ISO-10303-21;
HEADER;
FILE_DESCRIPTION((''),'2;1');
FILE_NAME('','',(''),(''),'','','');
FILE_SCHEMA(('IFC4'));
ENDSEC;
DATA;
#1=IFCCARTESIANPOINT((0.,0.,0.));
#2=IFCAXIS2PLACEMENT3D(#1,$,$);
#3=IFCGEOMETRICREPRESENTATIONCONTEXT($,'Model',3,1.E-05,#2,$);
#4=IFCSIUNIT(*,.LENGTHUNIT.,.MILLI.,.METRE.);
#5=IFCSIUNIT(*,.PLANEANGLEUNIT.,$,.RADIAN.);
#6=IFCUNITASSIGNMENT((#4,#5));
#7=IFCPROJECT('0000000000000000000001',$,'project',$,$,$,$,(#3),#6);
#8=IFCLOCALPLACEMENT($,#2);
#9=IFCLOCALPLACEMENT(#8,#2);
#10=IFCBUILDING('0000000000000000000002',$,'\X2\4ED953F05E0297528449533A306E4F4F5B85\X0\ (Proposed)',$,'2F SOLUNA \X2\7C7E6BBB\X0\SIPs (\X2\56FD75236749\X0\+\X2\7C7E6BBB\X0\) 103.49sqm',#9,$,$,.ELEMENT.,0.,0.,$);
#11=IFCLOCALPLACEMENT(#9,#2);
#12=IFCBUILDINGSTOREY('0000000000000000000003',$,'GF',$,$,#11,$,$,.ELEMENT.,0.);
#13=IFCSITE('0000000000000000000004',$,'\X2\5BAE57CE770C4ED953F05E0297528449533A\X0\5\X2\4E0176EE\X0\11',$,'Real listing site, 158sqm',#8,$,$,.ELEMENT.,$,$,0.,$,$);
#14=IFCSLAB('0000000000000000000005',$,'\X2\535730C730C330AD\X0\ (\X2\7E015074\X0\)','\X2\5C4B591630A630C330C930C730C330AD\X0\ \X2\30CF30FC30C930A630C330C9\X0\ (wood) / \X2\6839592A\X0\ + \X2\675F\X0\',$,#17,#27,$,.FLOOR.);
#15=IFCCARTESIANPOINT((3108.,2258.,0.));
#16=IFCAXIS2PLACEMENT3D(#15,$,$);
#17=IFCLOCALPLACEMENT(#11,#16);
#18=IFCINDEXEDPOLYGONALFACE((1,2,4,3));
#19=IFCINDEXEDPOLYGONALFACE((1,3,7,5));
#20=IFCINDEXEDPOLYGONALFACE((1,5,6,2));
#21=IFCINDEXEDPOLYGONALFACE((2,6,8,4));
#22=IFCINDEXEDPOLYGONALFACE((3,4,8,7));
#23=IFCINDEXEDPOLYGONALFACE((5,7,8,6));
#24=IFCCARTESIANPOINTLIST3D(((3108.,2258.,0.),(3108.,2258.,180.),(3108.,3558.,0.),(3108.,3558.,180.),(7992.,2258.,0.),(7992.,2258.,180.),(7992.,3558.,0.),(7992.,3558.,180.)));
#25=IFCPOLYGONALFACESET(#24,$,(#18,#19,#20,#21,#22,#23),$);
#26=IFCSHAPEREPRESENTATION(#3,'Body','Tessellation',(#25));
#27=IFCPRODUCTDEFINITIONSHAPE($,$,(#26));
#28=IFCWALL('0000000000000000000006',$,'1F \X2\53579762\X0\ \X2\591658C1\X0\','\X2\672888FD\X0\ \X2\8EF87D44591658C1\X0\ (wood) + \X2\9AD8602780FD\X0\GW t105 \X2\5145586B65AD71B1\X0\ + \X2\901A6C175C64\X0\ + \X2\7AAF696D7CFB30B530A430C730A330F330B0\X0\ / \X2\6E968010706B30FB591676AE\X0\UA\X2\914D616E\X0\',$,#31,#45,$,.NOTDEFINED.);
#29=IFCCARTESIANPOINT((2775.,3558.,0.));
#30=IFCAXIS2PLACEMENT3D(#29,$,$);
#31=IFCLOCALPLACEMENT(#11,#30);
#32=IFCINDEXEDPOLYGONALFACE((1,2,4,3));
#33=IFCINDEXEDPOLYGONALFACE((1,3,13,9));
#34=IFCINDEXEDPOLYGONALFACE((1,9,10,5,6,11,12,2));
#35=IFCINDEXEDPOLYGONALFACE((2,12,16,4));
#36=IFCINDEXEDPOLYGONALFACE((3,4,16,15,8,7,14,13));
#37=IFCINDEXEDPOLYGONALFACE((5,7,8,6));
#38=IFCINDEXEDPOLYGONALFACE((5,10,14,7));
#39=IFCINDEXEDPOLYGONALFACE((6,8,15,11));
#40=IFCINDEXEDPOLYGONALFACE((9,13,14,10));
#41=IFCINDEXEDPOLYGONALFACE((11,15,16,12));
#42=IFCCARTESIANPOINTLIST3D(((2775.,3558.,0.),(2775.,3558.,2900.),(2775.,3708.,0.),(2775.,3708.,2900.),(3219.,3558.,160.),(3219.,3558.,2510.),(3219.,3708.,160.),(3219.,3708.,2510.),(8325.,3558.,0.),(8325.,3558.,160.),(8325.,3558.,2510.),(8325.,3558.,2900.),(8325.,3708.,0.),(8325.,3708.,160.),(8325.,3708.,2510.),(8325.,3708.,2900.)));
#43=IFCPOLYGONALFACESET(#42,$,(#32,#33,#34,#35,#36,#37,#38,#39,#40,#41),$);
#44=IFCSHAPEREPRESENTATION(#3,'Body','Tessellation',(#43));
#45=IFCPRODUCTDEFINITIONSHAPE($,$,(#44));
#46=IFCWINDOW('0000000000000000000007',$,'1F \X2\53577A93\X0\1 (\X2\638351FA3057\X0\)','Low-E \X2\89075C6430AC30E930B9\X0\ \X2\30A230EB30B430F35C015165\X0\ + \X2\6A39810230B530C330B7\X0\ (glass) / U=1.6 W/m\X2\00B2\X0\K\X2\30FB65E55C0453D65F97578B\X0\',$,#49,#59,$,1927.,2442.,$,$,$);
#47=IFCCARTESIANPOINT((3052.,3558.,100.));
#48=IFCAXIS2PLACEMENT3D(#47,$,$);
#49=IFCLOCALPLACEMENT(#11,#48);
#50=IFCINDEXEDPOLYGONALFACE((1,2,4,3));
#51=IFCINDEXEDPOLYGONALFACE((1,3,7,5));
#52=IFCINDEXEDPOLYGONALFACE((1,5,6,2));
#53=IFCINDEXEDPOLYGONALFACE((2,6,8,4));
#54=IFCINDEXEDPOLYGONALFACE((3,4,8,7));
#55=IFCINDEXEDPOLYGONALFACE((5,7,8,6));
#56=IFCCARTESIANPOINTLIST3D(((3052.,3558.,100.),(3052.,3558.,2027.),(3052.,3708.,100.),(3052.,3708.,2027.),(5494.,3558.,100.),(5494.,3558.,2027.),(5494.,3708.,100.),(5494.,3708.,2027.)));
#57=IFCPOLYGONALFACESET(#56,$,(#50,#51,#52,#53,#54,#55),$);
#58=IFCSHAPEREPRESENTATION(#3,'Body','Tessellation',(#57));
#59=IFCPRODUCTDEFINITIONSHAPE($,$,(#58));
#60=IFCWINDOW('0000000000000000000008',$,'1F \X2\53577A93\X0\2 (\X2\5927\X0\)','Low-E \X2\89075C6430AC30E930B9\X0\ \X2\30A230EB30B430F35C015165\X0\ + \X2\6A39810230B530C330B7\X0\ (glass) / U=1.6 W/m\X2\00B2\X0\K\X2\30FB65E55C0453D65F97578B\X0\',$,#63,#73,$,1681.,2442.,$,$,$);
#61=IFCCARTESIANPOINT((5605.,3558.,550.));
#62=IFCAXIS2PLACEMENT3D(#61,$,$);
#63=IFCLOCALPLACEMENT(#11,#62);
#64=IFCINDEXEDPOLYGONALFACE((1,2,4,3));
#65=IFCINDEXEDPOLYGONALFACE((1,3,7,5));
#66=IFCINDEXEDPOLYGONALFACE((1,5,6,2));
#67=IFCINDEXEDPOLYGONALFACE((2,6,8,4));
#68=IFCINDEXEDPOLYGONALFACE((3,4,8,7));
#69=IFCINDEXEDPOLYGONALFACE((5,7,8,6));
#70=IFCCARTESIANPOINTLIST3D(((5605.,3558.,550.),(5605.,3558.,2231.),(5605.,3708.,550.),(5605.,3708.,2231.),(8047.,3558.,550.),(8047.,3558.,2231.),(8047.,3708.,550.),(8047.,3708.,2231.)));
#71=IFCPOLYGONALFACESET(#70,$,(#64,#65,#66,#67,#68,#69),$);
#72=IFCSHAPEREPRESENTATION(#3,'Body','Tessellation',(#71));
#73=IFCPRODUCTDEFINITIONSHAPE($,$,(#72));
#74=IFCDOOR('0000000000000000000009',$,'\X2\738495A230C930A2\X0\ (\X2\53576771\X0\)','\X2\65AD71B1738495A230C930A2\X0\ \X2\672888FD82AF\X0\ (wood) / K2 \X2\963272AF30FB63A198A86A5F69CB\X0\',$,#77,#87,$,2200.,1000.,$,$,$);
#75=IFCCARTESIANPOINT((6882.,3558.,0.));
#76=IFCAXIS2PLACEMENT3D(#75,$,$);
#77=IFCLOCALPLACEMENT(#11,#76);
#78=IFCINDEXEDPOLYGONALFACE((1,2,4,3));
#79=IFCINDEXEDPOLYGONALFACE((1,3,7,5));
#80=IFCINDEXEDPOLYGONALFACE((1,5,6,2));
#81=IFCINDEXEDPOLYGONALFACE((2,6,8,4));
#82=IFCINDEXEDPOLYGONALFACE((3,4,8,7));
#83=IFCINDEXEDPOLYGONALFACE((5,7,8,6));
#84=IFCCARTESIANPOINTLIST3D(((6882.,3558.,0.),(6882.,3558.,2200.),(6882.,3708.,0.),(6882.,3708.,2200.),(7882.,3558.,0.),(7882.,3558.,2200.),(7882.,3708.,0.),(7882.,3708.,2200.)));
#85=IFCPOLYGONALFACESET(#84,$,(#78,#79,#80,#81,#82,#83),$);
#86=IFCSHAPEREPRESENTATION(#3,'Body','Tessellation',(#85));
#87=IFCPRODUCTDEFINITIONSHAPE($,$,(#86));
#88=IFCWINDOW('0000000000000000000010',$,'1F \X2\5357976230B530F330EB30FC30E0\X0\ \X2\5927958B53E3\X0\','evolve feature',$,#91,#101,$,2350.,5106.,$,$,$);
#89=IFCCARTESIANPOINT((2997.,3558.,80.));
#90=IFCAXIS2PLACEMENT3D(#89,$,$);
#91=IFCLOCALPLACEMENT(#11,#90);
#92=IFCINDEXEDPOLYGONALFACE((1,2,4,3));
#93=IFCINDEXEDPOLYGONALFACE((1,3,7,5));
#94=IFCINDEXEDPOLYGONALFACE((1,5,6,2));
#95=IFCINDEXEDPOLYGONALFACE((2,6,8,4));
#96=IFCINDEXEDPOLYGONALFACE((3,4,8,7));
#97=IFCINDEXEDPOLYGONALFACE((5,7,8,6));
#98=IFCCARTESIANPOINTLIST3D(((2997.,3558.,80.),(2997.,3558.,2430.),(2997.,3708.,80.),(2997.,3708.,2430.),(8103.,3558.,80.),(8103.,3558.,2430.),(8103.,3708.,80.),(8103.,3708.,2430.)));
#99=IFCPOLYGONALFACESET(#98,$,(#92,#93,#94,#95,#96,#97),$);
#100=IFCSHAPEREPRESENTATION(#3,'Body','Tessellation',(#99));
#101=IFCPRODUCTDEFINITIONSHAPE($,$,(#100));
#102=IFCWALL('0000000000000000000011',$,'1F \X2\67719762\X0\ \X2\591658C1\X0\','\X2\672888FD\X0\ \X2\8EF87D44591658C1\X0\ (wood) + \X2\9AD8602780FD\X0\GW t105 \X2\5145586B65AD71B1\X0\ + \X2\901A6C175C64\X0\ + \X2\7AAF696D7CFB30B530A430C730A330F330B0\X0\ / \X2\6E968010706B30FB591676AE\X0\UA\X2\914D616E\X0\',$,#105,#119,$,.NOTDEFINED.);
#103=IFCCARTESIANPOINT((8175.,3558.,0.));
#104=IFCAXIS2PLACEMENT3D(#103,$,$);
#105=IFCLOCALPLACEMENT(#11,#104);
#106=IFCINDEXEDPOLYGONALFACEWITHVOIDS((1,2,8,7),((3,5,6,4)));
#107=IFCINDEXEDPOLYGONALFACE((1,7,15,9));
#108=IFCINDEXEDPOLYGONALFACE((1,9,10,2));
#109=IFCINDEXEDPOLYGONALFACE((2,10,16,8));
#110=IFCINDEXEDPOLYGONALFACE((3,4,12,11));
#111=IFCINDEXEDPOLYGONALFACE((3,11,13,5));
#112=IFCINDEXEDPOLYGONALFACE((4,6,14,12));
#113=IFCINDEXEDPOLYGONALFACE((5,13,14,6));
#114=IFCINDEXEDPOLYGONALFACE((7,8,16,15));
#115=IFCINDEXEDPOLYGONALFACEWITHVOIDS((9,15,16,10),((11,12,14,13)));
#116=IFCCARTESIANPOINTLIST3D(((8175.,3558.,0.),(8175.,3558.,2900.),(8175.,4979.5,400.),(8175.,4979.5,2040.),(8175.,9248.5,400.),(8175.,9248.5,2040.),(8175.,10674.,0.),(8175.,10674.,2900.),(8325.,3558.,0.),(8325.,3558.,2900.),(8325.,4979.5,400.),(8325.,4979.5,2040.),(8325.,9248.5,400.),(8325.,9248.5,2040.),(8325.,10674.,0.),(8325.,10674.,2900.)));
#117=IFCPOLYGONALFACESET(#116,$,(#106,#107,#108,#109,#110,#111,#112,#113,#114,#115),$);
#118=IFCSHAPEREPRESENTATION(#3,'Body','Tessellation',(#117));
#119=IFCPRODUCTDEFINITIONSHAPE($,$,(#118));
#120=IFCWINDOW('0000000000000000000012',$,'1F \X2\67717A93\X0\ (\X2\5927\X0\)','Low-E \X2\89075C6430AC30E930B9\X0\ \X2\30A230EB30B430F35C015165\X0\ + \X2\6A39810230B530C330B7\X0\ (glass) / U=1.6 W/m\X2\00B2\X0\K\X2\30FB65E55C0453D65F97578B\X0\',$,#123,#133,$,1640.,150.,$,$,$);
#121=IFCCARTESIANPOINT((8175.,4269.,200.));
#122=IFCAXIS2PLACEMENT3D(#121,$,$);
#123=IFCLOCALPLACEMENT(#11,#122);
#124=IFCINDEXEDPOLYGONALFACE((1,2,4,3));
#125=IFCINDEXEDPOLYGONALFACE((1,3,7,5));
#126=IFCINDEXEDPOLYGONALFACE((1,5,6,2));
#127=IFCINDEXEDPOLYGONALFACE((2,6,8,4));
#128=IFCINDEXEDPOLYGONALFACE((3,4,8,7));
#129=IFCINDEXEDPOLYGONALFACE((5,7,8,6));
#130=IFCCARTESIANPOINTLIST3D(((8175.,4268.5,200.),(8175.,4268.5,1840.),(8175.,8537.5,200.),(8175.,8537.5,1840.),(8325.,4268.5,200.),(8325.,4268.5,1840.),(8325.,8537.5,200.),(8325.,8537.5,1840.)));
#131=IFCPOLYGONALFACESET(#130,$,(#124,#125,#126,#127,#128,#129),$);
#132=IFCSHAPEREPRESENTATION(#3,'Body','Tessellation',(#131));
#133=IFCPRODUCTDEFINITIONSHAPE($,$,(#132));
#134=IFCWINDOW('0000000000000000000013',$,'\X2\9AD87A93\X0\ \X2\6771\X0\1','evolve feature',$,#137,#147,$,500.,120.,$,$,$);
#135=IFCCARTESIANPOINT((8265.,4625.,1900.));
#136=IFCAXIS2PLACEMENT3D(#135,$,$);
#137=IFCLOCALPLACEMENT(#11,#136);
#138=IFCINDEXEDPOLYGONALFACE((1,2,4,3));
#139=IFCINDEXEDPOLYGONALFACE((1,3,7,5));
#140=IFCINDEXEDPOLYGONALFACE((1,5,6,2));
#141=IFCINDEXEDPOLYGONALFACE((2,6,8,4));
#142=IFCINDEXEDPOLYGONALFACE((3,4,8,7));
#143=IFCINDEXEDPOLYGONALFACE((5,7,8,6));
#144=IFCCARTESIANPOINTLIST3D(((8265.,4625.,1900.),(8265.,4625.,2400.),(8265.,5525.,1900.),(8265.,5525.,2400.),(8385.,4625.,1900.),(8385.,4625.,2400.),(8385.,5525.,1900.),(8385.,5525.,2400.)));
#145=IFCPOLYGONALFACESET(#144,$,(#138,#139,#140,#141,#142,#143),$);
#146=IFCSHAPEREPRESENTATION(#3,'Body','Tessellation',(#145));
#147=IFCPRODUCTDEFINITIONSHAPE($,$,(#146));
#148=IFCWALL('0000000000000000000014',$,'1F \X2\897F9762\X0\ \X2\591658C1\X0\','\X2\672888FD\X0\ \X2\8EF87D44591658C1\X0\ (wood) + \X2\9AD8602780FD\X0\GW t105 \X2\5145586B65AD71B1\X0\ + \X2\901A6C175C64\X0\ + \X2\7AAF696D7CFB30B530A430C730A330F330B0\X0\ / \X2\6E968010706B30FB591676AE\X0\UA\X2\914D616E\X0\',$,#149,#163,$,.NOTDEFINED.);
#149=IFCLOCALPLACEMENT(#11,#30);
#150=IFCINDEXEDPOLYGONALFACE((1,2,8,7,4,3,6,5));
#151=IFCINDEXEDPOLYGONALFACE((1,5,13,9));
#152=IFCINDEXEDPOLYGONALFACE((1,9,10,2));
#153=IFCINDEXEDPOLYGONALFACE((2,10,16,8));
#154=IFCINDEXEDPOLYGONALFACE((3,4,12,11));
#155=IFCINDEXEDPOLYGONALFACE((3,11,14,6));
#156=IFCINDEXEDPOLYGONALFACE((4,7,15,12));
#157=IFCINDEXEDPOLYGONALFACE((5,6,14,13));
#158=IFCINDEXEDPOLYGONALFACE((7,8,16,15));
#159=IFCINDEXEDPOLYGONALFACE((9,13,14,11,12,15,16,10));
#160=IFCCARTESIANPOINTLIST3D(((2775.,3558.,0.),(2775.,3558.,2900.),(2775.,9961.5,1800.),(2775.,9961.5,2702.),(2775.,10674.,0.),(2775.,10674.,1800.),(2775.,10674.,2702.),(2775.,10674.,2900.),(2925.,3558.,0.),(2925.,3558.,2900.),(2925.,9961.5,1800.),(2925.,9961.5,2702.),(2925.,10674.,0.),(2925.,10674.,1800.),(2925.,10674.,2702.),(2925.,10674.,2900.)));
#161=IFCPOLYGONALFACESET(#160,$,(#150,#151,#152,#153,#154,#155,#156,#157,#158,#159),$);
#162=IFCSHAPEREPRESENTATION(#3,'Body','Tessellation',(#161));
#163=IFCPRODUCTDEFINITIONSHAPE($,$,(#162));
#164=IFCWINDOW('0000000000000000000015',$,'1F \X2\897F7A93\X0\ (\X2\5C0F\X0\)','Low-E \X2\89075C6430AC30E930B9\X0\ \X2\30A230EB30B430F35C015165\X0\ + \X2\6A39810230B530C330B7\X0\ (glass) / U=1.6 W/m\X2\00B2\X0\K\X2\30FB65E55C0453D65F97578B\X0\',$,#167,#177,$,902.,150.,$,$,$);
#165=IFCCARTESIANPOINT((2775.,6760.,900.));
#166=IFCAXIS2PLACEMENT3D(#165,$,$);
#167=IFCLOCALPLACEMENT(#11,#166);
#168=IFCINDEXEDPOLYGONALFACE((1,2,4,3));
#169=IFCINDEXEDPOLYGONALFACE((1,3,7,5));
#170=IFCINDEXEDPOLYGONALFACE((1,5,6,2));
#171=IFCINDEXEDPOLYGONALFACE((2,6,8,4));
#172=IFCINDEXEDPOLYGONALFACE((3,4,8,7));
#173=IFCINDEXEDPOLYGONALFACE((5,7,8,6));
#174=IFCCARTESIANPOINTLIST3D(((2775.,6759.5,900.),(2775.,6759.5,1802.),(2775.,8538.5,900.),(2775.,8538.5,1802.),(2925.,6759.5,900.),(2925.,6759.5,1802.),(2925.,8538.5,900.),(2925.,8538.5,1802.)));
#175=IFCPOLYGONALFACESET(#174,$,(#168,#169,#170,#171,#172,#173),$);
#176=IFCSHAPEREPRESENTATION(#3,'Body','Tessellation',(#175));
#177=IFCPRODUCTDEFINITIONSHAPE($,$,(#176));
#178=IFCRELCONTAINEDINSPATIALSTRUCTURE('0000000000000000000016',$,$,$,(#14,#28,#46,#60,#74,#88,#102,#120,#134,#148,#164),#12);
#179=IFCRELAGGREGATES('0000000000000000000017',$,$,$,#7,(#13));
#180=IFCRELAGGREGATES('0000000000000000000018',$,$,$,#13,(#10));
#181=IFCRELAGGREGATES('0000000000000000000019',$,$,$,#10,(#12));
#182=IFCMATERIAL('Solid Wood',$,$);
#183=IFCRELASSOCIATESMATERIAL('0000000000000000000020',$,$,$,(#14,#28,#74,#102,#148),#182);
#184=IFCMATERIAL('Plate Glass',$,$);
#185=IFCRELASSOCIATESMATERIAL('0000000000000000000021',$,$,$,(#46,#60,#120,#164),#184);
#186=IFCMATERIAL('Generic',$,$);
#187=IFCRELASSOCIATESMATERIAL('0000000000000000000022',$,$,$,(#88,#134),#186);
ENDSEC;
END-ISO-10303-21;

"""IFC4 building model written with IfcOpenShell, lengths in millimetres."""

from ifc_helpers import new_model, si_unit, frame, frame_2d, origin, place, context, project, spatial, rectangle, extrude, material, element, fill, save


model = new_model("IFC4")

# Units and contexts
model_context = context("Model", 3, precision=1e-05, world=origin())
ifc_project = project(units=[si_unit("LENGTHUNIT", "METRE", prefix="MILLI"), si_unit("PLANEANGLEUNIT", "RADIAN")], contexts=[model_context])

# Site, building, storey
site_placement = place(None, origin())
site = spatial("IfcSite", under=ifc_project, at=site_placement, Name="宮城県仙台市青葉区5丁目11", ObjectType="Real listing site, 158sqm", CompositionType="ELEMENT", RefElevation=0.0)
building_placement = place(site_placement, origin())
building = spatial("IfcBuilding", under=site, at=building_placement, Name="仙台市青葉区の住宅 (Proposed)", ObjectType="2F SOLUNA 籾殻SIPs (国産杉+籾殻) 103.49sqm", CompositionType="ELEMENT", ElevationOfRefHeight=0.0, ElevationOfTerrain=0.0)
storey_placement = place(building_placement, origin())
storey = spatial("IfcBuildingStorey", under=building, at=storey_placement, Name="GF", CompositionType="ELEMENT", Elevation=0.0)

# Slab
ifc_material_1 = material(Name="Solid Wood")
slab_1_placement = place(storey_placement, frame((3108.0, 2258.0, 0.0)))
element("IfcSlab", 1, at=slab_1_placement, inside=storey, material=ifc_material_1, Name="南デッキ (縁側)", Description="屋外ウッドデッキ ハードウッド (wood) / 根太 + 束", PredefinedType="FLOOR", context=model_context, shape_type="SweptSolid", body=[
    extrude(rectangle(XDim=4884.0, YDim=1300.0, at=frame_2d((2442.0, 650.0))), frame((3108.0, 2258.0, 0.0)), (0.0, 0.0, 1.0), 180.0),
])
ifc_material_2 = material(Name="Generic")

# Wall, openings, windows, door
wall_1_placement = place(storey_placement, frame((2775.0, 3558.0, 0.0)))
wall_1 = element("IfcWall", 2, at=wall_1_placement, inside=storey, material=ifc_material_1, Name="1F 南面 外壁", Description="木製 軸組外壁 (wood) + 高性能GW t105 充填断熱 + 通気層 + 窯業系サイディング / 準耐火・外皮UA配慮", PredefinedType="NOTDEFINED", context=model_context, shape_type="SweptSolid", body=[
    extrude(rectangle(XDim=5550.0, YDim=150.0, at=frame_2d((2775.0, 75.0))), frame((2775.0, 3558.0, 0.0)), (0.0, 0.0, 1.0), 2900.0),
])
opening_1_placement = place(storey_placement, frame((3052.0, 3558.0, 100.0)))
opening_1 = element("IfcOpeningElement", 3, at=opening_1_placement, cuts=wall_1, PredefinedType="NOTDEFINED", context=model_context, shape_type="SweptSolid", body=[
    extrude(rectangle(XDim=2442.0, YDim=150.0, at=frame_2d((1221.0, 75.0))), frame((3052.0, 3558.0, 100.0)), (0.0, 0.0, 1.0), 1927.0),
])
opening_2_placement = place(storey_placement, frame((5605.0, 3558.0, 550.0)))
opening_2 = element("IfcOpeningElement", 4, at=opening_2_placement, cuts=wall_1, PredefinedType="NOTDEFINED", context=model_context, shape_type="SweptSolid", body=[
    extrude(rectangle(XDim=2442.0, YDim=150.0, at=frame_2d((1221.0, 75.0))), frame((5605.0, 3558.0, 550.0)), (0.0, 0.0, 1.0), 1681.0),
])
opening_3_placement = place(storey_placement, frame((6882.0, 3558.0, 0.0)))
opening_3 = element("IfcOpeningElement", 5, at=opening_3_placement, cuts=wall_1, PredefinedType="NOTDEFINED", context=model_context, shape_type="SweptSolid", body=[
    extrude(rectangle(XDim=1000.0, YDim=150.0, at=frame_2d((500.0, 75.0))), frame((6882.0, 3558.0, 0.0)), (0.0, 0.0, 1.0), 2200.0),
])
opening_4_placement = place(storey_placement, frame((2997.0, 3558.0, 80.0)))
opening_4 = element("IfcOpeningElement", 6, at=opening_4_placement, cuts=wall_1, PredefinedType="NOTDEFINED", context=model_context, shape_type="SweptSolid", body=[
    extrude(rectangle(XDim=5106.0, YDim=150.0, at=frame_2d((2553.0, 75.0))), frame((2997.0, 3558.0, 80.0)), (0.0, 0.0, 1.0), 2350.0),
])
ifc_material_3 = material(Name="Plate Glass")
window_1_placement = place(storey_placement, frame((3052.0, 3558.0, 100.0)))
window_1 = element("IfcWindow", 7, at=window_1_placement, inside=storey, material=ifc_material_3, Name="1F 南窓1 (掃出し)", Description="Low-E 複層ガラス アルゴン封入 + 樹脂サッシ (glass) / U=1.6 W/m²K・日射取得型", OverallHeight=1927.0, OverallWidth=2442.0, context=model_context, shape_type="SweptSolid", body=[
    extrude(rectangle(XDim=2442.0, YDim=150.0, at=frame_2d((1221.0, 75.0))), frame((3052.0, 3558.0, 100.0)), (0.0, 0.0, 1.0), 1927.0),
])
fill(opening_1, window_1)
window_2_placement = place(storey_placement, frame((5605.0, 3558.0, 550.0)))
window_2 = element("IfcWindow", 8, at=window_2_placement, inside=storey, material=ifc_material_3, Name="1F 南窓2 (大)", Description="Low-E 複層ガラス アルゴン封入 + 樹脂サッシ (glass) / U=1.6 W/m²K・日射取得型", OverallHeight=1681.0, OverallWidth=2442.0, context=model_context, shape_type="SweptSolid", body=[
    extrude(rectangle(XDim=2442.0, YDim=150.0, at=frame_2d((1221.0, 75.0))), frame((5605.0, 3558.0, 550.0)), (0.0, 0.0, 1.0), 1681.0),
])
fill(opening_2, window_2)
door_placement = place(storey_placement, frame((6882.0, 3558.0, 0.0)))
door = element("IfcDoor", 9, at=door_placement, inside=storey, material=ifc_material_1, Name="玄関ドア (南東)", Description="断熱玄関ドア 木製芯 (wood) / K2 防犯・採風機構", OverallHeight=2200.0, OverallWidth=1000.0, context=model_context, shape_type="SweptSolid", body=[
    extrude(rectangle(XDim=1000.0, YDim=150.0, at=frame_2d((500.0, 75.0))), frame((6882.0, 3558.0, 0.0)), (0.0, 0.0, 1.0), 2200.0),
])
fill(opening_3, door)
window_3_placement = place(storey_placement, frame((2997.0, 3558.0, 80.0)))
window_3 = element("IfcWindow", 10, at=window_3_placement, inside=storey, material=ifc_material_2, Name="1F 南面サンルーム 大開口", Description="evolve feature", OverallHeight=2350.0, OverallWidth=5106.0, context=model_context, shape_type="SweptSolid", body=[
    extrude(rectangle(XDim=5106.0, YDim=150.0, at=frame_2d((2553.0, 75.0))), frame((2997.0, 3558.0, 80.0)), (0.0, 0.0, 1.0), 2350.0),
])
fill(opening_4, window_3)

# Wall, openings, windows
wall_2_placement = place(storey_placement, frame((8175.0, 3558.0, 0.0)))
wall_2 = element("IfcWall", 11, at=wall_2_placement, inside=storey, material=ifc_material_1, Name="1F 東面 外壁", Description="木製 軸組外壁 (wood) + 高性能GW t105 充填断熱 + 通気層 + 窯業系サイディング / 準耐火・外皮UA配慮", PredefinedType="NOTDEFINED", context=model_context, shape_type="SweptSolid", body=[
    extrude(rectangle(XDim=150.0, YDim=7116.0, at=frame_2d((75.0, 3558.0))), frame((8175.0, 3558.0, 0.0)), (0.0, 0.0, 1.0), 2900.0),
])
opening_5_placement = place(storey_placement, frame((8175.0, 4269.0, 200.0)))
opening_5 = element("IfcOpeningElement", 12, at=opening_5_placement, cuts=wall_2, PredefinedType="NOTDEFINED", context=model_context, shape_type="SweptSolid", body=[
    extrude(rectangle(XDim=150.0, YDim=4269.0, at=frame_2d((75.0, 2134.0))), frame((8175.0, 4269.0, 200.0)), (0.0, 0.0, 1.0), 1640.0),
])
opening_6_placement = place(storey_placement, frame((8265.0, 4625.0, 1900.0)))
opening_6 = element("IfcOpeningElement", 13, at=opening_6_placement, cuts=wall_2, PredefinedType="NOTDEFINED", context=model_context, shape_type="SweptSolid", body=[
    extrude(rectangle(XDim=120.0, YDim=900.0, at=frame_2d((60.0, 450.0))), frame((8265.0, 4625.0, 1900.0)), (0.0, 0.0, 1.0), 500.0),
])
window_4_placement = place(storey_placement, frame((8175.0, 4269.0, 200.0)))
window_4 = element("IfcWindow", 14, at=window_4_placement, inside=storey, material=ifc_material_3, Name="1F 東窓 (大)", Description="Low-E 複層ガラス アルゴン封入 + 樹脂サッシ (glass) / U=1.6 W/m²K・日射取得型", OverallHeight=1640.0, OverallWidth=150.0, context=model_context, shape_type="SweptSolid", body=[
    extrude(rectangle(XDim=150.0, YDim=4269.0, at=frame_2d((75.0, 2134.0))), frame((8175.0, 4269.0, 200.0)), (0.0, 0.0, 1.0), 1640.0),
])
fill(opening_5, window_4)
window_5_placement = place(storey_placement, frame((8265.0, 4625.0, 1900.0)))
window_5 = element("IfcWindow", 15, at=window_5_placement, inside=storey, material=ifc_material_2, Name="高窓 東1", Description="evolve feature", OverallHeight=500.0, OverallWidth=120.0, context=model_context, shape_type="SweptSolid", body=[
    extrude(rectangle(XDim=120.0, YDim=900.0, at=frame_2d((60.0, 450.0))), frame((8265.0, 4625.0, 1900.0)), (0.0, 0.0, 1.0), 500.0),
])
fill(opening_6, window_5)

# Wall, opening, window
wall_3_placement = place(storey_placement, frame((2775.0, 3558.0, 0.0)))
wall_3 = element("IfcWall", 16, at=wall_3_placement, inside=storey, material=ifc_material_1, Name="1F 西面 外壁", Description="木製 軸組外壁 (wood) + 高性能GW t105 充填断熱 + 通気層 + 窯業系サイディング / 準耐火・外皮UA配慮", PredefinedType="NOTDEFINED", context=model_context, shape_type="SweptSolid", body=[
    extrude(rectangle(XDim=150.0, YDim=7116.0, at=frame_2d((75.0, 3558.0))), frame((2775.0, 3558.0, 0.0)), (0.0, 0.0, 1.0), 2900.0),
])
opening_7_placement = place(storey_placement, frame((2775.0, 6760.0, 900.0)))
opening_7 = element("IfcOpeningElement", 17, at=opening_7_placement, cuts=wall_3, PredefinedType="NOTDEFINED", context=model_context, shape_type="SweptSolid", body=[
    extrude(rectangle(XDim=150.0, YDim=1779.0, at=frame_2d((75.0, 889.0))), frame((2775.0, 6760.0, 900.0)), (0.0, 0.0, 1.0), 902.0),
])
window_6_placement = place(storey_placement, frame((2775.0, 6760.0, 900.0)))
window_6 = element("IfcWindow", 18, at=window_6_placement, inside=storey, material=ifc_material_3, Name="1F 西窓 (小)", Description="Low-E 複層ガラス アルゴン封入 + 樹脂サッシ (glass) / U=1.6 W/m²K・日射取得型", OverallHeight=902.0, OverallWidth=150.0, context=model_context, shape_type="SweptSolid", body=[
    extrude(rectangle(XDim=150.0, YDim=1779.0, at=frame_2d((75.0, 889.0))), frame((2775.0, 6760.0, 900.0)), (0.0, 0.0, 1.0), 902.0),
])
fill(opening_7, window_6)

save(model, "model.ifc")
